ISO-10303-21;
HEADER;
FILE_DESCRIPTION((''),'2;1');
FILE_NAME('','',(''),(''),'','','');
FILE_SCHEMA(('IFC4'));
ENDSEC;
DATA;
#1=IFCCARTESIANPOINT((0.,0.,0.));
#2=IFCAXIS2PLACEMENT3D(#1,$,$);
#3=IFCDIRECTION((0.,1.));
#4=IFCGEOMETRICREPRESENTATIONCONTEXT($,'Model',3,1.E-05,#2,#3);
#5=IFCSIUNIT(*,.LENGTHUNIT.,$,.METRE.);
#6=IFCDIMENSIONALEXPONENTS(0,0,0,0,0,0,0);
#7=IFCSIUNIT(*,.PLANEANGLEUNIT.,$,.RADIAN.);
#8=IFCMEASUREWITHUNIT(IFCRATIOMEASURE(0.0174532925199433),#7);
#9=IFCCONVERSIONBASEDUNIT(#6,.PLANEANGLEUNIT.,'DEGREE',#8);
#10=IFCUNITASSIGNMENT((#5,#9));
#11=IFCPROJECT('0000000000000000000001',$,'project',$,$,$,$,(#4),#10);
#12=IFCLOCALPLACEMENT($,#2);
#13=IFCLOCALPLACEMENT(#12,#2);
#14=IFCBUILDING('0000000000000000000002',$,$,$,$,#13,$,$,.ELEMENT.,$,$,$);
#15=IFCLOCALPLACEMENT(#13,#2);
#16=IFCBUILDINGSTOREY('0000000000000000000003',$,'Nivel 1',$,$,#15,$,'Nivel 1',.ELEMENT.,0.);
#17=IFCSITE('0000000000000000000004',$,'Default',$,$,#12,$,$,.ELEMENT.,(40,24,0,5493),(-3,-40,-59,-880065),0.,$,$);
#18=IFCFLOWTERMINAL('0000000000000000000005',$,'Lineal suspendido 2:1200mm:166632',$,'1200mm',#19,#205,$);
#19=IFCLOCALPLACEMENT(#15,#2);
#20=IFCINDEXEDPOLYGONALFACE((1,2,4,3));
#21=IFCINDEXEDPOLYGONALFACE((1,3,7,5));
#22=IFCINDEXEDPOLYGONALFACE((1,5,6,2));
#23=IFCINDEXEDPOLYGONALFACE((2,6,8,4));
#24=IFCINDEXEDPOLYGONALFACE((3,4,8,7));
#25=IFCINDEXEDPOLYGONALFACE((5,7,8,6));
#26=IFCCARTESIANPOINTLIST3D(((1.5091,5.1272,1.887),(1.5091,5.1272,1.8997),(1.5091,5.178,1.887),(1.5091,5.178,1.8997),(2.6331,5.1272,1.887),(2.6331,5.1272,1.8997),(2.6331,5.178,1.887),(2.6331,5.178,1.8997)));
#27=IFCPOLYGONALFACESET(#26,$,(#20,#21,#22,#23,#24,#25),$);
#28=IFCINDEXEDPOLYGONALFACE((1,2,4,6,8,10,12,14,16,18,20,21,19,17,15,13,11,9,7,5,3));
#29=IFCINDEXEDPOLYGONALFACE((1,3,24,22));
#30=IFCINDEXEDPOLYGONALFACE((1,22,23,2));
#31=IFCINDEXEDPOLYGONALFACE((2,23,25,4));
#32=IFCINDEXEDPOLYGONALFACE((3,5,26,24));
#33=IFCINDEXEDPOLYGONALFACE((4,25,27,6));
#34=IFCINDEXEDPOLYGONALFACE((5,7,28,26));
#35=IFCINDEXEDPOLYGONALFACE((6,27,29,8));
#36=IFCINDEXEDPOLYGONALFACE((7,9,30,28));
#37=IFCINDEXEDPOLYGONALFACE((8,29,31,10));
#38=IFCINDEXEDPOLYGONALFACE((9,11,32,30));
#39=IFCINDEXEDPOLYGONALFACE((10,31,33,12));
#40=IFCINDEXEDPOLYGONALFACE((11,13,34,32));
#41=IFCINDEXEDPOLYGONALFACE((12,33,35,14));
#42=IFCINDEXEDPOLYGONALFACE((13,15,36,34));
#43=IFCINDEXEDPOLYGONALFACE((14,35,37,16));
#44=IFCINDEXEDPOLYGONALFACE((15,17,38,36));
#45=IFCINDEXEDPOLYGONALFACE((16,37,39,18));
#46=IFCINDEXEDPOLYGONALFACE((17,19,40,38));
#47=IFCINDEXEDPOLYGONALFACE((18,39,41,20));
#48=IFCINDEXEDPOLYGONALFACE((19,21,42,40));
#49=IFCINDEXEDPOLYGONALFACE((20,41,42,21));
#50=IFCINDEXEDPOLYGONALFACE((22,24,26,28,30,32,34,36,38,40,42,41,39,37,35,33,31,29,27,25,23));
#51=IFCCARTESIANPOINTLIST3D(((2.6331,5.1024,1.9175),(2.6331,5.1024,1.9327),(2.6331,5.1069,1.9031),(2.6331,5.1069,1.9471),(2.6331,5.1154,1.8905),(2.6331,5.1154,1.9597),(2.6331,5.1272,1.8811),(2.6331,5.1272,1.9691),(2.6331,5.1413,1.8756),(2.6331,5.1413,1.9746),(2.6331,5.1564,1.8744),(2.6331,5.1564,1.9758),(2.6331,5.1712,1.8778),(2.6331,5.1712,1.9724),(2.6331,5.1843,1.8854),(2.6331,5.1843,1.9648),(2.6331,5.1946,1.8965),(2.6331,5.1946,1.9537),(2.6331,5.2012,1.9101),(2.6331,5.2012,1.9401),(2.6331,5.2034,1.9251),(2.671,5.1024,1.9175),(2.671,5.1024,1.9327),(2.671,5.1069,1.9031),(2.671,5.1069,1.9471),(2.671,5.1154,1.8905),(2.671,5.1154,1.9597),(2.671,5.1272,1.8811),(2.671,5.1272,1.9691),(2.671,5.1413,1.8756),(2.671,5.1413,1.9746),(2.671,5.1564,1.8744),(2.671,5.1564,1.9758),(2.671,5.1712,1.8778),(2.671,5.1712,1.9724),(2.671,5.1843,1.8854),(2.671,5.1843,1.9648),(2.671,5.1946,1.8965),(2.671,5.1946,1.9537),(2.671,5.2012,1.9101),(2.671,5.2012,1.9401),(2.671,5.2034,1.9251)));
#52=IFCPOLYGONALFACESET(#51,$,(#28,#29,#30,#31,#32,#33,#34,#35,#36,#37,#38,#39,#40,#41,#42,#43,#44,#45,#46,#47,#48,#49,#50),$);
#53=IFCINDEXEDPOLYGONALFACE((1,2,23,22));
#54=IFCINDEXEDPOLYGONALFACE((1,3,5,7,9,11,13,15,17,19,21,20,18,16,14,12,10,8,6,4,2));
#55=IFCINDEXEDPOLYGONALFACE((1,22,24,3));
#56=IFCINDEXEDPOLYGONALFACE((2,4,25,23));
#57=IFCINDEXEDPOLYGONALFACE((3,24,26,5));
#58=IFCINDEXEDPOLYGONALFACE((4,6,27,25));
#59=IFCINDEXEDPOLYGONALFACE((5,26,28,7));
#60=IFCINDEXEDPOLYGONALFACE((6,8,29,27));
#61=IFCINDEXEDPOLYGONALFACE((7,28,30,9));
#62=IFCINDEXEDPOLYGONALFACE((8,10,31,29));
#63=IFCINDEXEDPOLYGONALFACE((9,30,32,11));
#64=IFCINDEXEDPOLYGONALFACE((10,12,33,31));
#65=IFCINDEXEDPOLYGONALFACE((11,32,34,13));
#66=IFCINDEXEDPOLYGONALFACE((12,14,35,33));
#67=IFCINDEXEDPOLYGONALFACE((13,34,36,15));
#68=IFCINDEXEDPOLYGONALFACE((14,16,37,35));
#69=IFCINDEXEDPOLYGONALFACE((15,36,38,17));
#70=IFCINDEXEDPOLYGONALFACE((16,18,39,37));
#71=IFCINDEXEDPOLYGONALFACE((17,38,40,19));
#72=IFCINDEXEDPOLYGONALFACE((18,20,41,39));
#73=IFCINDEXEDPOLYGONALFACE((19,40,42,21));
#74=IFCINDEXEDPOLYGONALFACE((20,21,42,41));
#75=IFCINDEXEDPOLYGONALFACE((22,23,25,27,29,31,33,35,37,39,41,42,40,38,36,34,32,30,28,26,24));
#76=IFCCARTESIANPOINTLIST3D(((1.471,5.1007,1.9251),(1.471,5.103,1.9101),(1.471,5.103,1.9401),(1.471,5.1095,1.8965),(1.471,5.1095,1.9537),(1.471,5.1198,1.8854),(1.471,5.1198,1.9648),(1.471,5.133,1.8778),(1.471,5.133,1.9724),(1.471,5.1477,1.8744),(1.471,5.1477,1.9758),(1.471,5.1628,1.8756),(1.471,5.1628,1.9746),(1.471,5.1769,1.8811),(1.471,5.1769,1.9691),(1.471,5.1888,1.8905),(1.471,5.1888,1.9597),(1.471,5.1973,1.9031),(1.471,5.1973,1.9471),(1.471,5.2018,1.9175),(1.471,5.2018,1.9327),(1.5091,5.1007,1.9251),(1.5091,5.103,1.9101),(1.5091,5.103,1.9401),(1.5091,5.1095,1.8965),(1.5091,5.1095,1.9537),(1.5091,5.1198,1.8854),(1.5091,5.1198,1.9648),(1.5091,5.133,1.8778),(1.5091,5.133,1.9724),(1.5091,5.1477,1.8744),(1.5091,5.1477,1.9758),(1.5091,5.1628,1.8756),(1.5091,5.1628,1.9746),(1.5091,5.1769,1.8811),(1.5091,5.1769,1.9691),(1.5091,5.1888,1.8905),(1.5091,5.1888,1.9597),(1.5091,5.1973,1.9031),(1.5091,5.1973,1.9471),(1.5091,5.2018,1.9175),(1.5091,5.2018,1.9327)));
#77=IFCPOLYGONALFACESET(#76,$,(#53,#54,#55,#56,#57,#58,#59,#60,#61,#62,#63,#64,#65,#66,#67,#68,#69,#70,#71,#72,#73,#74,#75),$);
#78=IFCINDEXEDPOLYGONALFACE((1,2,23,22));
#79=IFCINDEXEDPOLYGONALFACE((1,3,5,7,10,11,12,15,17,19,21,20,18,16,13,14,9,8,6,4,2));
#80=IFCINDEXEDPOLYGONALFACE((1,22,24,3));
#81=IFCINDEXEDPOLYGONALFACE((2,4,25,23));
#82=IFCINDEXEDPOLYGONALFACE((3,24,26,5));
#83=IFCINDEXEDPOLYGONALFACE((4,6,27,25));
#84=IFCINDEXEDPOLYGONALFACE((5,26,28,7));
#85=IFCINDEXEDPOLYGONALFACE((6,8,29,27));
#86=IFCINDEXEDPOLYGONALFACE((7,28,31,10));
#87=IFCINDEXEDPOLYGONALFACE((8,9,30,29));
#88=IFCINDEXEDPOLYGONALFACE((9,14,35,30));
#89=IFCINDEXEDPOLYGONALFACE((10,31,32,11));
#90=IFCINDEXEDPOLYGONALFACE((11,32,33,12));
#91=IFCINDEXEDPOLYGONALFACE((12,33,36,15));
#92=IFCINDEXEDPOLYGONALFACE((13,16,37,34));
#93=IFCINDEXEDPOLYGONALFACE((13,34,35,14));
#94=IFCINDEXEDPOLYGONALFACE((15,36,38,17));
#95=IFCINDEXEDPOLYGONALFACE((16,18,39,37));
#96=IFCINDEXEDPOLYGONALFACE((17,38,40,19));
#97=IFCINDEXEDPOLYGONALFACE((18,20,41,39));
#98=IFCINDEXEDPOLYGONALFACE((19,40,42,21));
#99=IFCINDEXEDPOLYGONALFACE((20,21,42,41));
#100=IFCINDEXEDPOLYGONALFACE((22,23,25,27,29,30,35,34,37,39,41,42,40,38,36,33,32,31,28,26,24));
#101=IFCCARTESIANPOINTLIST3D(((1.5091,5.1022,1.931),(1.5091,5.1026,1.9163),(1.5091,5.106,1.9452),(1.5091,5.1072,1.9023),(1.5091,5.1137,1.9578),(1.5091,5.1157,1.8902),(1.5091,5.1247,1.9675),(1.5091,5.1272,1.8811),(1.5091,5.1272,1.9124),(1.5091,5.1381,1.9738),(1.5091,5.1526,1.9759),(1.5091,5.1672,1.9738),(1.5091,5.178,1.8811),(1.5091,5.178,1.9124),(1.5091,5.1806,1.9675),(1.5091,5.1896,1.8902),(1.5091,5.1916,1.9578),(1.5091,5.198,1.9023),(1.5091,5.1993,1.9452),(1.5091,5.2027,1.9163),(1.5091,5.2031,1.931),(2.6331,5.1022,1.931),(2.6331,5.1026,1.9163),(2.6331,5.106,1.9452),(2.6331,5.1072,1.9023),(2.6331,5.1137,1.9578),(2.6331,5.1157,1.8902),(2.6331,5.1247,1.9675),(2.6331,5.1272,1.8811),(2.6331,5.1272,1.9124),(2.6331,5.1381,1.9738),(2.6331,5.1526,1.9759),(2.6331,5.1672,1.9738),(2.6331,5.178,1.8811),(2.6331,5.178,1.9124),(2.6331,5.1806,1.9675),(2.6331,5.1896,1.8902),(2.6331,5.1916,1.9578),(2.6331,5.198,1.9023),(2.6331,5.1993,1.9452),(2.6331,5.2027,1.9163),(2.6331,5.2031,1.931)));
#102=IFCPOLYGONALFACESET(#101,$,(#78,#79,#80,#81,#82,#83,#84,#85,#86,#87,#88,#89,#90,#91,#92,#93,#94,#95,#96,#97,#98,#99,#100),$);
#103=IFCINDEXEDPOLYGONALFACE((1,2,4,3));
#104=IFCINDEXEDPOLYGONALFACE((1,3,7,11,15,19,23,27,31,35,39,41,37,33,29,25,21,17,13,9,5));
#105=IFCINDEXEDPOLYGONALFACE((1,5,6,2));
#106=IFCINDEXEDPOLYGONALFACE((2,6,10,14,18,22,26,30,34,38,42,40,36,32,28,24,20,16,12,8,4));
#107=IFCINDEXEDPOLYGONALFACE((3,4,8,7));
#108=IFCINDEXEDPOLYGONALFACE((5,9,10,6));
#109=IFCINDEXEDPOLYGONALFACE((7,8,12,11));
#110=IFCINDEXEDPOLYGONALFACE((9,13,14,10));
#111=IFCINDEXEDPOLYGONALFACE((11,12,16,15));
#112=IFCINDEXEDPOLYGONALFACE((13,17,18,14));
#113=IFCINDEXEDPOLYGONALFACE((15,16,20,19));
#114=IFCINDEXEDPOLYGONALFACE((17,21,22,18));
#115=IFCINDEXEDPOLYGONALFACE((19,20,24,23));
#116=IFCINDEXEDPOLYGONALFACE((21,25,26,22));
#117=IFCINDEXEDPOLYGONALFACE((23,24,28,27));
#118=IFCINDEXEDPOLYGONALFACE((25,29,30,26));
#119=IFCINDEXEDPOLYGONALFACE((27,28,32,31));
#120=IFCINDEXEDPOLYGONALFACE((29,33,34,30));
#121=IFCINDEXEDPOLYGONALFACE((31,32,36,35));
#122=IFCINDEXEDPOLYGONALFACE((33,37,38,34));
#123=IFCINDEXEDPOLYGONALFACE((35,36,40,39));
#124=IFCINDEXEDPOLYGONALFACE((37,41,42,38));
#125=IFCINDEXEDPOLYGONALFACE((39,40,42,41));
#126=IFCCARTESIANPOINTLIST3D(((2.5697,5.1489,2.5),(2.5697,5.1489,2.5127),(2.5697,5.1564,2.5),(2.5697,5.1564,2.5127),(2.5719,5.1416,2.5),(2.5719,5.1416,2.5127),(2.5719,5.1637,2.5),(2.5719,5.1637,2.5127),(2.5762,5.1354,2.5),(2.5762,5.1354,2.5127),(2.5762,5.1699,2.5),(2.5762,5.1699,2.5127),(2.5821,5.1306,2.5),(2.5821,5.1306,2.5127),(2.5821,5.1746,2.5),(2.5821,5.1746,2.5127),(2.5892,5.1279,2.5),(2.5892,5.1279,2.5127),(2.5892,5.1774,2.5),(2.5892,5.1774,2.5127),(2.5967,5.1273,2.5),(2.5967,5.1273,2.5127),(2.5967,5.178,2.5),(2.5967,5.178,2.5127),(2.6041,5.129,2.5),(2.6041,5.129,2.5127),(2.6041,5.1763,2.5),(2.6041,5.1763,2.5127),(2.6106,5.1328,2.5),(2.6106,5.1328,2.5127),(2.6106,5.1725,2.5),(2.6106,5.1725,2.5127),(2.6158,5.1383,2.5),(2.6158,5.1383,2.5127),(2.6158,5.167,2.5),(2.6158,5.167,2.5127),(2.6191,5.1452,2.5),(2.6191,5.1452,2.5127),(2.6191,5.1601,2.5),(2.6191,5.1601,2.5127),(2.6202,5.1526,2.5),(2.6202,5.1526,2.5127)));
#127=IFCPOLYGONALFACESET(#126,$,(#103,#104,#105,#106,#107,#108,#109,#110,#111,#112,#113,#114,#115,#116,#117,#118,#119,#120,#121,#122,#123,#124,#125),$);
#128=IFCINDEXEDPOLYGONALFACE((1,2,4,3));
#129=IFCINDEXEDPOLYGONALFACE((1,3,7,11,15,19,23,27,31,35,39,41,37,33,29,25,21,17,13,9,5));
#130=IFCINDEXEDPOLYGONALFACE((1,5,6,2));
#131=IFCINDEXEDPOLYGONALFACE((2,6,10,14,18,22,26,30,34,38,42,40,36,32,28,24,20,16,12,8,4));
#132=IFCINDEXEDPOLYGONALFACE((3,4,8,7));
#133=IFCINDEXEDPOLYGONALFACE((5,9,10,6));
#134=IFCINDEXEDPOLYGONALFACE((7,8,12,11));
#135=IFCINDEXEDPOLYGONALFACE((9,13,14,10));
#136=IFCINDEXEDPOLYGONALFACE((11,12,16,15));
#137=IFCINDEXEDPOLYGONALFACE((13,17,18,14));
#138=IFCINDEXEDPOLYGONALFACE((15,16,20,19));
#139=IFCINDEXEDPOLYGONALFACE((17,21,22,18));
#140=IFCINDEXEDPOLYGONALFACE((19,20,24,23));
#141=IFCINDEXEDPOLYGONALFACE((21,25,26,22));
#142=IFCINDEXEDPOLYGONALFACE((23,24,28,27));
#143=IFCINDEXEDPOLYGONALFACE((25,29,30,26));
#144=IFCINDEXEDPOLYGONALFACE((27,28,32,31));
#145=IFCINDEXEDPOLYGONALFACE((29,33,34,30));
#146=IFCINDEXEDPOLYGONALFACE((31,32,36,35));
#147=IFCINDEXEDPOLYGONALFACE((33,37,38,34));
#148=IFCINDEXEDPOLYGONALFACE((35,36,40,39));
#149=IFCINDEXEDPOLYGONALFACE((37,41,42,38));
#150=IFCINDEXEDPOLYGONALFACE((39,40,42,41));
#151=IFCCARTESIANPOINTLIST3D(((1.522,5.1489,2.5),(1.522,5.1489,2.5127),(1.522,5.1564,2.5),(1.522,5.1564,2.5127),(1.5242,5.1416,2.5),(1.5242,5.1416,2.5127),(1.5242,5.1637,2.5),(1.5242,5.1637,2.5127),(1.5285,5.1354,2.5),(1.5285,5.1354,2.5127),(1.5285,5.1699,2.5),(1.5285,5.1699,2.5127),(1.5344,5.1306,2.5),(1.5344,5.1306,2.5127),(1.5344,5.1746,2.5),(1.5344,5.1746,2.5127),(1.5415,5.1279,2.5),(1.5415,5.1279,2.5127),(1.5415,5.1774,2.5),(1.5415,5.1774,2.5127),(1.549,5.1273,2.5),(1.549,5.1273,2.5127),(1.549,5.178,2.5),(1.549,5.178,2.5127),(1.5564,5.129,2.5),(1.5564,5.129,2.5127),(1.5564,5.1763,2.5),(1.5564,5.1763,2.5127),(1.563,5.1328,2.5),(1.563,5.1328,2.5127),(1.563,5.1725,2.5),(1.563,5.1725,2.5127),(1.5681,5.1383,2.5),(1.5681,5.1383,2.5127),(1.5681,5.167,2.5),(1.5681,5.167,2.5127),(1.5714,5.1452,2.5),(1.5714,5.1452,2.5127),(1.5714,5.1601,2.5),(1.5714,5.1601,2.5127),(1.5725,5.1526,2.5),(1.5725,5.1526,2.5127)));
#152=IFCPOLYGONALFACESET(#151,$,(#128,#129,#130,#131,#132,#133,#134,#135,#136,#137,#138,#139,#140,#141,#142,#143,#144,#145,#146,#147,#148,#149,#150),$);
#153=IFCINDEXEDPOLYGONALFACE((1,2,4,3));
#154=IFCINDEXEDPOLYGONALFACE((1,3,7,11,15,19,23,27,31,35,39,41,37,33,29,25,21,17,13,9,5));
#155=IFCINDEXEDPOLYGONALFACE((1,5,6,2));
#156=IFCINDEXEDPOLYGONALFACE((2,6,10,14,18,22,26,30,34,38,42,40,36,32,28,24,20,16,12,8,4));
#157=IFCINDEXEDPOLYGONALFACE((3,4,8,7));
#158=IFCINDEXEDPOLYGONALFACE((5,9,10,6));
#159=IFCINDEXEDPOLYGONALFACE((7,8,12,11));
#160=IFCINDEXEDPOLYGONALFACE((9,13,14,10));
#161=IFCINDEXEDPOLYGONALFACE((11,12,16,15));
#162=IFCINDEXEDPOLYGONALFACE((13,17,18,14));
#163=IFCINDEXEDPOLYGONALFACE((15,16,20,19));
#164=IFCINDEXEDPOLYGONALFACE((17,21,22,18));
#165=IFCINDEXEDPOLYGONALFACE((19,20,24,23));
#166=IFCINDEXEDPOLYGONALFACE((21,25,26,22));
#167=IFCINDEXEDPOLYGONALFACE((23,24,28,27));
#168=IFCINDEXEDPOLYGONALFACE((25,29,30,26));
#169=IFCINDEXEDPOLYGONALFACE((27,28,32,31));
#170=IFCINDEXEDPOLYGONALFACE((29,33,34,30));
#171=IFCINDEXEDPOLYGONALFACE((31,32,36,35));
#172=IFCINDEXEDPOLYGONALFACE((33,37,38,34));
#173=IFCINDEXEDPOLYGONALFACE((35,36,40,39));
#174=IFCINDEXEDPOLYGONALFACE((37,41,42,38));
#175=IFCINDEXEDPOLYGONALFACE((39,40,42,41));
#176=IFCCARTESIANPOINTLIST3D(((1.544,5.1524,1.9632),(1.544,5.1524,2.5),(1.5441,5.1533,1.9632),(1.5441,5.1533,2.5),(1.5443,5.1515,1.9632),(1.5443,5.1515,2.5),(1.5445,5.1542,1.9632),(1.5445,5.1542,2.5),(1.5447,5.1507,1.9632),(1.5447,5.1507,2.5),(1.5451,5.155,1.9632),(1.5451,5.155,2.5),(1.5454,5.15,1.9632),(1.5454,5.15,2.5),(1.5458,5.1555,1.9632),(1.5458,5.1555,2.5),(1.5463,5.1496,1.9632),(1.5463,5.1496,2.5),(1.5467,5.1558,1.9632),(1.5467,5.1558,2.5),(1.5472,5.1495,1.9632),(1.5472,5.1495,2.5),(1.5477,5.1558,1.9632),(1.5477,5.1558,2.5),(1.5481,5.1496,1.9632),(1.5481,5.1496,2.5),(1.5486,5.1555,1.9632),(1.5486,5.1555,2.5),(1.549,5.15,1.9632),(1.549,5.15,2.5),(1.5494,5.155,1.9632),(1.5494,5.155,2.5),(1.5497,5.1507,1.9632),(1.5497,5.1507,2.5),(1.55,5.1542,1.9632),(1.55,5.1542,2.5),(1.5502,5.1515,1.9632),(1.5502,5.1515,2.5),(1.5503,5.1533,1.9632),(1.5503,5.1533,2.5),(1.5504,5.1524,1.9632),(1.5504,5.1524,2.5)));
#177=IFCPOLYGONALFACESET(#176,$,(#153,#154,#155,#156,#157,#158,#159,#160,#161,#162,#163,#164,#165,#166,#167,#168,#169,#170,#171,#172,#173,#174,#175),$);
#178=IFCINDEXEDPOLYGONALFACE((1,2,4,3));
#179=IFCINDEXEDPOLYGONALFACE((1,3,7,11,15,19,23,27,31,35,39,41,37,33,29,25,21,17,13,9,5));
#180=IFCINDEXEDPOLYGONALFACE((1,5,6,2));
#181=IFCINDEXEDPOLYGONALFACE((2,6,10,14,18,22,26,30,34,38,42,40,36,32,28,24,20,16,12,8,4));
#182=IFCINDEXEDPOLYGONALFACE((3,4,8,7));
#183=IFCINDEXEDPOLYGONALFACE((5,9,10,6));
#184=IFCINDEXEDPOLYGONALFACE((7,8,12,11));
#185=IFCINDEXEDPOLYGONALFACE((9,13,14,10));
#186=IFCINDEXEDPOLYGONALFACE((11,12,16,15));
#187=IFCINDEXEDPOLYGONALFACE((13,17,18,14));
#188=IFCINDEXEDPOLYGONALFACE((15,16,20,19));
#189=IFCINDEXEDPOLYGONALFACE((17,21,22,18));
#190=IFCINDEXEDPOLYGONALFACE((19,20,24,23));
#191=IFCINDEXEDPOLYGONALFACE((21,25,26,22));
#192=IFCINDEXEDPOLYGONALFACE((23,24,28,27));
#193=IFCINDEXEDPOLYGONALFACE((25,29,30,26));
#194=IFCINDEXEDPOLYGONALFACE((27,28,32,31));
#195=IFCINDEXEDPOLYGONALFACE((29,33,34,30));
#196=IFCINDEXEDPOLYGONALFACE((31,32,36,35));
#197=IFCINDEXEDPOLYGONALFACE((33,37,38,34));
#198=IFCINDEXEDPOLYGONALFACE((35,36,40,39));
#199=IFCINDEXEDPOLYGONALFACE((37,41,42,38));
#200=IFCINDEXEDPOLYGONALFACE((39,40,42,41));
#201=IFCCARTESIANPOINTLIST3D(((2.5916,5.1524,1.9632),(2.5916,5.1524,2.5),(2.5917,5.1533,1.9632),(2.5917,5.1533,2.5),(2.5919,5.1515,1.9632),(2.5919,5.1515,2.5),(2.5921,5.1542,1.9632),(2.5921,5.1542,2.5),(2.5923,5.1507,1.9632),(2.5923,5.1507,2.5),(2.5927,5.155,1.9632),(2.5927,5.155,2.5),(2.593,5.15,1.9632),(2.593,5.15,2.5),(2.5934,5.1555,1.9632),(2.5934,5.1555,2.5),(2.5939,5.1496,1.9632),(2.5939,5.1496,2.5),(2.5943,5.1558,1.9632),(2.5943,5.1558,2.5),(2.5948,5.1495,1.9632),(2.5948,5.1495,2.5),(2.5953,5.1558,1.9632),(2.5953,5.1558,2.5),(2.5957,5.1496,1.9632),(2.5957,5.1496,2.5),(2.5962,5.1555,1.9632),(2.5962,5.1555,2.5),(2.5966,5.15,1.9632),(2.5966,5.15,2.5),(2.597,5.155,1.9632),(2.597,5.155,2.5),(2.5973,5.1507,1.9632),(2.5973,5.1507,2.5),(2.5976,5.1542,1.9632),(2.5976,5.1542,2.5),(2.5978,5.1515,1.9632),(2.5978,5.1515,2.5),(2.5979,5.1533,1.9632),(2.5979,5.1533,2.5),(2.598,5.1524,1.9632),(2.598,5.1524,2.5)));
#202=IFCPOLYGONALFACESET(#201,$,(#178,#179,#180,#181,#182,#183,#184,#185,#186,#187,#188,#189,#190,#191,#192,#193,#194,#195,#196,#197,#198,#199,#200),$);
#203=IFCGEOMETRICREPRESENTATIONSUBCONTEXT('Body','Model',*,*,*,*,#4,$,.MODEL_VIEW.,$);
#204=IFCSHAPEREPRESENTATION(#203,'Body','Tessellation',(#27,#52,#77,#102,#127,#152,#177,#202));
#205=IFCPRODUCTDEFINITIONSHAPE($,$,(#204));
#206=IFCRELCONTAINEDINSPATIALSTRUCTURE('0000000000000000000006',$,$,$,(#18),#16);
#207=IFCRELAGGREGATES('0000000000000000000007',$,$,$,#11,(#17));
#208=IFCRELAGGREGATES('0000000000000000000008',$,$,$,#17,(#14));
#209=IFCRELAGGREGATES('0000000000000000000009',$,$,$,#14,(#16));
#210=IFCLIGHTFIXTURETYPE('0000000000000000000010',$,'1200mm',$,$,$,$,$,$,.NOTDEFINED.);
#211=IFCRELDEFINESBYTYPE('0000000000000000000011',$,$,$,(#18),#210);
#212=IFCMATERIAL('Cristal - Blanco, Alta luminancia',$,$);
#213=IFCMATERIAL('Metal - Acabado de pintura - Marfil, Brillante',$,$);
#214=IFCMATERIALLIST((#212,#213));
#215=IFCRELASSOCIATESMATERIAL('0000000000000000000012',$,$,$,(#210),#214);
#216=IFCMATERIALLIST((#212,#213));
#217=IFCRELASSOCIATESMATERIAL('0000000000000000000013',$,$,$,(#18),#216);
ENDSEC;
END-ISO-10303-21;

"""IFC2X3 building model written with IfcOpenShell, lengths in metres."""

from ifc_helpers import new_model, entity, si_unit, converted_unit, direction, frame, frame_2d, origin, origin_2d_with_axis, place, context, subcontext, project, spatial, polyline, circle_curve, parameter, trimmed, segment, composite_curve, rectangle, circle, outline, extrude, source, transform, mapped, material, material_list, type_object, type_shapes, element, save


model = new_model("IFC2X3")

# Units and contexts
model_context = context("Model", 3, precision=1e-05, world=origin(), true_north=direction((0.0, 1.0)))
body_context = subcontext(model_context, "Body", "Model", "MODEL_VIEW")
ifc_project = project(units=[si_unit("LENGTHUNIT", "METRE"), converted_unit("PLANEANGLEUNIT", "DEGREE", entity("IfcRatioMeasure", 0.0174532925199433), si_unit("PLANEANGLEUNIT", "RADIAN"), dimensions=[0, 0, 0, 0, 0, 0, 0])], contexts=[model_context])

# Site, building, storey
site_placement = place(None, origin())
site = spatial("IfcSite", under=ifc_project, at=site_placement, Name="Default", CompositionType="ELEMENT", RefLatitude=(40, 24, 0, 5493), RefLongitude=(-3, -40, -59, -880065), RefElevation=0.0)
building_placement = place(site_placement, origin())
building = spatial("IfcBuilding", under=site, at=building_placement, CompositionType="ELEMENT")
storey_placement = place(building_placement, origin())
storey = spatial("IfcBuildingStorey", under=building, at=storey_placement, Name="Nivel 1", LongName="Nivel 1", CompositionType="ELEMENT", Elevation=0.0)

# Flow terminal
ifc_material_1 = material(Name="Cristal - Blanco, Alta luminancia")
ifc_material_2 = material(Name="Metal - Acabado de pintura - Marfil, Brillante")
ifc_material_list_1 = material_list([ifc_material_1, ifc_material_2])
light_fixture_type = type_object("IfcLightFixtureType", Name="1200mm", PredefinedType="NOTDEFINED", material=ifc_material_list_1)
shared_shape = source(origin(), body_context, "Body", "SweptSolid", [
    extrude(rectangle(XDim=1.124, YDim=0.0508, at=origin_2d_with_axis()), frame((0.0001, 0.0, 1.8127), z_axis=(0.0, 0.0, 1.0), x_axis=(-1.0, 0.0, 0.0)), (0.0, 0.0, 1.0), 0.0127),
    extrude(circle(Radius=0.0508, at=frame_2d((0.0, 0.0), x_axis=(1.0, 0.0))), frame((0.5621, 0.0, 1.8508), z_axis=(1.0, 0.0, 0.0), x_axis=(0.0, 1.0, 0.0)), (0.0, 0.0, 1.0), 0.0379),
    extrude(circle(Radius=0.0508, at=frame_2d((0.0, 0.0), x_axis=(1.0, 0.0))), frame((-0.6, -0.0011, 1.8508), z_axis=(1.0, 0.0, 0.0), x_axis=(0.0, -1.0, 0.0)), (0.0, 0.0, 1.0), 0.0381),
    extrude(outline(composite_curve([segment(trimmed(circle_curve(frame_2d((0.0125, 0.0), x_axis=(0.0, 1.0)), 0.0508), [parameter(120.0)], [parameter(270.0)], True, "PARAMETER"), True, "CONTINUOUS"), segment(trimmed(circle_curve(frame_2d((0.0125, 0.0), x_axis=(0.0, 1.0)), 0.0508), [parameter(270.0)], [parameter(60.0)], True, "PARAMETER"), True, "CONTINUOUS"), segment(polyline([(-0.0315, 0.0254), (-0.0002, 0.0254)]), True, "CONTINUOUS"), segment(polyline([(-0.0002, 0.0254), (-0.0002, -0.0254)]), True, "CONTINUOUS"), segment(polyline([(-0.0002, -0.0254), (-0.0315, -0.0254)]), True, "CONTINUOUS")], self_intersect=False)), frame((-0.5619, 0.0, 1.8383), z_axis=(-1.0, 0.0, 0.0), x_axis=(0.0, 0.0, 1.0)), (0.0, 0.0, -1.0), 1.124),
    extrude(circle(Radius=0.0254, at=frame_2d((0.0, 0.0), x_axis=(1.0, 0.0))), frame((0.5238, 0.0, 2.4257)), (0.0, 0.0, 1.0), 0.0127),
    extrude(circle(Radius=0.0254, at=frame_2d((0.0, 0.0), x_axis=(1.0, 0.0))), frame((-0.5239, 0.0, 2.4257)), (0.0, 0.0, 1.0), 0.0127),
    extrude(circle(Radius=0.0032, at=frame_2d((0.0, 0.0), x_axis=(1.0, 0.0))), frame((-0.5238, 0.0, 1.8889), z_axis=(0.0, 0.0, 1.0), x_axis=(0.0, -1.0, 0.0)), (0.0, 0.0, 1.0), 0.5368),
    extrude(circle(Radius=0.0032, at=frame_2d((0.0, 0.0), x_axis=(1.0, 0.0))), frame((0.5238, 0.0, 1.8889), z_axis=(0.0, 0.0, 1.0), x_axis=(0.0, -1.0, 0.0)), (0.0, 0.0, 1.0), 0.5368),
])
type_shapes(light_fixture_type, [shared_shape])
ifc_material_list_2 = material_list([ifc_material_1, ifc_material_2])
flow_terminal_1_placement = place(storey_placement, frame((2.071, 5.1526, 0.0743)))
element("IfcFlowTerminal", 1, at=flow_terminal_1_placement, inside=storey, type_object=light_fixture_type, material=ifc_material_list_2, Name="Lineal suspendido 2:1200mm:166632", ObjectType="1200mm", context=body_context, shape_type="MappedRepresentation", body=[
    mapped(shared_shape, transform((0.0, 0.0, 0.0), scale=1.0)),
])

save(model, "model.ifc")
